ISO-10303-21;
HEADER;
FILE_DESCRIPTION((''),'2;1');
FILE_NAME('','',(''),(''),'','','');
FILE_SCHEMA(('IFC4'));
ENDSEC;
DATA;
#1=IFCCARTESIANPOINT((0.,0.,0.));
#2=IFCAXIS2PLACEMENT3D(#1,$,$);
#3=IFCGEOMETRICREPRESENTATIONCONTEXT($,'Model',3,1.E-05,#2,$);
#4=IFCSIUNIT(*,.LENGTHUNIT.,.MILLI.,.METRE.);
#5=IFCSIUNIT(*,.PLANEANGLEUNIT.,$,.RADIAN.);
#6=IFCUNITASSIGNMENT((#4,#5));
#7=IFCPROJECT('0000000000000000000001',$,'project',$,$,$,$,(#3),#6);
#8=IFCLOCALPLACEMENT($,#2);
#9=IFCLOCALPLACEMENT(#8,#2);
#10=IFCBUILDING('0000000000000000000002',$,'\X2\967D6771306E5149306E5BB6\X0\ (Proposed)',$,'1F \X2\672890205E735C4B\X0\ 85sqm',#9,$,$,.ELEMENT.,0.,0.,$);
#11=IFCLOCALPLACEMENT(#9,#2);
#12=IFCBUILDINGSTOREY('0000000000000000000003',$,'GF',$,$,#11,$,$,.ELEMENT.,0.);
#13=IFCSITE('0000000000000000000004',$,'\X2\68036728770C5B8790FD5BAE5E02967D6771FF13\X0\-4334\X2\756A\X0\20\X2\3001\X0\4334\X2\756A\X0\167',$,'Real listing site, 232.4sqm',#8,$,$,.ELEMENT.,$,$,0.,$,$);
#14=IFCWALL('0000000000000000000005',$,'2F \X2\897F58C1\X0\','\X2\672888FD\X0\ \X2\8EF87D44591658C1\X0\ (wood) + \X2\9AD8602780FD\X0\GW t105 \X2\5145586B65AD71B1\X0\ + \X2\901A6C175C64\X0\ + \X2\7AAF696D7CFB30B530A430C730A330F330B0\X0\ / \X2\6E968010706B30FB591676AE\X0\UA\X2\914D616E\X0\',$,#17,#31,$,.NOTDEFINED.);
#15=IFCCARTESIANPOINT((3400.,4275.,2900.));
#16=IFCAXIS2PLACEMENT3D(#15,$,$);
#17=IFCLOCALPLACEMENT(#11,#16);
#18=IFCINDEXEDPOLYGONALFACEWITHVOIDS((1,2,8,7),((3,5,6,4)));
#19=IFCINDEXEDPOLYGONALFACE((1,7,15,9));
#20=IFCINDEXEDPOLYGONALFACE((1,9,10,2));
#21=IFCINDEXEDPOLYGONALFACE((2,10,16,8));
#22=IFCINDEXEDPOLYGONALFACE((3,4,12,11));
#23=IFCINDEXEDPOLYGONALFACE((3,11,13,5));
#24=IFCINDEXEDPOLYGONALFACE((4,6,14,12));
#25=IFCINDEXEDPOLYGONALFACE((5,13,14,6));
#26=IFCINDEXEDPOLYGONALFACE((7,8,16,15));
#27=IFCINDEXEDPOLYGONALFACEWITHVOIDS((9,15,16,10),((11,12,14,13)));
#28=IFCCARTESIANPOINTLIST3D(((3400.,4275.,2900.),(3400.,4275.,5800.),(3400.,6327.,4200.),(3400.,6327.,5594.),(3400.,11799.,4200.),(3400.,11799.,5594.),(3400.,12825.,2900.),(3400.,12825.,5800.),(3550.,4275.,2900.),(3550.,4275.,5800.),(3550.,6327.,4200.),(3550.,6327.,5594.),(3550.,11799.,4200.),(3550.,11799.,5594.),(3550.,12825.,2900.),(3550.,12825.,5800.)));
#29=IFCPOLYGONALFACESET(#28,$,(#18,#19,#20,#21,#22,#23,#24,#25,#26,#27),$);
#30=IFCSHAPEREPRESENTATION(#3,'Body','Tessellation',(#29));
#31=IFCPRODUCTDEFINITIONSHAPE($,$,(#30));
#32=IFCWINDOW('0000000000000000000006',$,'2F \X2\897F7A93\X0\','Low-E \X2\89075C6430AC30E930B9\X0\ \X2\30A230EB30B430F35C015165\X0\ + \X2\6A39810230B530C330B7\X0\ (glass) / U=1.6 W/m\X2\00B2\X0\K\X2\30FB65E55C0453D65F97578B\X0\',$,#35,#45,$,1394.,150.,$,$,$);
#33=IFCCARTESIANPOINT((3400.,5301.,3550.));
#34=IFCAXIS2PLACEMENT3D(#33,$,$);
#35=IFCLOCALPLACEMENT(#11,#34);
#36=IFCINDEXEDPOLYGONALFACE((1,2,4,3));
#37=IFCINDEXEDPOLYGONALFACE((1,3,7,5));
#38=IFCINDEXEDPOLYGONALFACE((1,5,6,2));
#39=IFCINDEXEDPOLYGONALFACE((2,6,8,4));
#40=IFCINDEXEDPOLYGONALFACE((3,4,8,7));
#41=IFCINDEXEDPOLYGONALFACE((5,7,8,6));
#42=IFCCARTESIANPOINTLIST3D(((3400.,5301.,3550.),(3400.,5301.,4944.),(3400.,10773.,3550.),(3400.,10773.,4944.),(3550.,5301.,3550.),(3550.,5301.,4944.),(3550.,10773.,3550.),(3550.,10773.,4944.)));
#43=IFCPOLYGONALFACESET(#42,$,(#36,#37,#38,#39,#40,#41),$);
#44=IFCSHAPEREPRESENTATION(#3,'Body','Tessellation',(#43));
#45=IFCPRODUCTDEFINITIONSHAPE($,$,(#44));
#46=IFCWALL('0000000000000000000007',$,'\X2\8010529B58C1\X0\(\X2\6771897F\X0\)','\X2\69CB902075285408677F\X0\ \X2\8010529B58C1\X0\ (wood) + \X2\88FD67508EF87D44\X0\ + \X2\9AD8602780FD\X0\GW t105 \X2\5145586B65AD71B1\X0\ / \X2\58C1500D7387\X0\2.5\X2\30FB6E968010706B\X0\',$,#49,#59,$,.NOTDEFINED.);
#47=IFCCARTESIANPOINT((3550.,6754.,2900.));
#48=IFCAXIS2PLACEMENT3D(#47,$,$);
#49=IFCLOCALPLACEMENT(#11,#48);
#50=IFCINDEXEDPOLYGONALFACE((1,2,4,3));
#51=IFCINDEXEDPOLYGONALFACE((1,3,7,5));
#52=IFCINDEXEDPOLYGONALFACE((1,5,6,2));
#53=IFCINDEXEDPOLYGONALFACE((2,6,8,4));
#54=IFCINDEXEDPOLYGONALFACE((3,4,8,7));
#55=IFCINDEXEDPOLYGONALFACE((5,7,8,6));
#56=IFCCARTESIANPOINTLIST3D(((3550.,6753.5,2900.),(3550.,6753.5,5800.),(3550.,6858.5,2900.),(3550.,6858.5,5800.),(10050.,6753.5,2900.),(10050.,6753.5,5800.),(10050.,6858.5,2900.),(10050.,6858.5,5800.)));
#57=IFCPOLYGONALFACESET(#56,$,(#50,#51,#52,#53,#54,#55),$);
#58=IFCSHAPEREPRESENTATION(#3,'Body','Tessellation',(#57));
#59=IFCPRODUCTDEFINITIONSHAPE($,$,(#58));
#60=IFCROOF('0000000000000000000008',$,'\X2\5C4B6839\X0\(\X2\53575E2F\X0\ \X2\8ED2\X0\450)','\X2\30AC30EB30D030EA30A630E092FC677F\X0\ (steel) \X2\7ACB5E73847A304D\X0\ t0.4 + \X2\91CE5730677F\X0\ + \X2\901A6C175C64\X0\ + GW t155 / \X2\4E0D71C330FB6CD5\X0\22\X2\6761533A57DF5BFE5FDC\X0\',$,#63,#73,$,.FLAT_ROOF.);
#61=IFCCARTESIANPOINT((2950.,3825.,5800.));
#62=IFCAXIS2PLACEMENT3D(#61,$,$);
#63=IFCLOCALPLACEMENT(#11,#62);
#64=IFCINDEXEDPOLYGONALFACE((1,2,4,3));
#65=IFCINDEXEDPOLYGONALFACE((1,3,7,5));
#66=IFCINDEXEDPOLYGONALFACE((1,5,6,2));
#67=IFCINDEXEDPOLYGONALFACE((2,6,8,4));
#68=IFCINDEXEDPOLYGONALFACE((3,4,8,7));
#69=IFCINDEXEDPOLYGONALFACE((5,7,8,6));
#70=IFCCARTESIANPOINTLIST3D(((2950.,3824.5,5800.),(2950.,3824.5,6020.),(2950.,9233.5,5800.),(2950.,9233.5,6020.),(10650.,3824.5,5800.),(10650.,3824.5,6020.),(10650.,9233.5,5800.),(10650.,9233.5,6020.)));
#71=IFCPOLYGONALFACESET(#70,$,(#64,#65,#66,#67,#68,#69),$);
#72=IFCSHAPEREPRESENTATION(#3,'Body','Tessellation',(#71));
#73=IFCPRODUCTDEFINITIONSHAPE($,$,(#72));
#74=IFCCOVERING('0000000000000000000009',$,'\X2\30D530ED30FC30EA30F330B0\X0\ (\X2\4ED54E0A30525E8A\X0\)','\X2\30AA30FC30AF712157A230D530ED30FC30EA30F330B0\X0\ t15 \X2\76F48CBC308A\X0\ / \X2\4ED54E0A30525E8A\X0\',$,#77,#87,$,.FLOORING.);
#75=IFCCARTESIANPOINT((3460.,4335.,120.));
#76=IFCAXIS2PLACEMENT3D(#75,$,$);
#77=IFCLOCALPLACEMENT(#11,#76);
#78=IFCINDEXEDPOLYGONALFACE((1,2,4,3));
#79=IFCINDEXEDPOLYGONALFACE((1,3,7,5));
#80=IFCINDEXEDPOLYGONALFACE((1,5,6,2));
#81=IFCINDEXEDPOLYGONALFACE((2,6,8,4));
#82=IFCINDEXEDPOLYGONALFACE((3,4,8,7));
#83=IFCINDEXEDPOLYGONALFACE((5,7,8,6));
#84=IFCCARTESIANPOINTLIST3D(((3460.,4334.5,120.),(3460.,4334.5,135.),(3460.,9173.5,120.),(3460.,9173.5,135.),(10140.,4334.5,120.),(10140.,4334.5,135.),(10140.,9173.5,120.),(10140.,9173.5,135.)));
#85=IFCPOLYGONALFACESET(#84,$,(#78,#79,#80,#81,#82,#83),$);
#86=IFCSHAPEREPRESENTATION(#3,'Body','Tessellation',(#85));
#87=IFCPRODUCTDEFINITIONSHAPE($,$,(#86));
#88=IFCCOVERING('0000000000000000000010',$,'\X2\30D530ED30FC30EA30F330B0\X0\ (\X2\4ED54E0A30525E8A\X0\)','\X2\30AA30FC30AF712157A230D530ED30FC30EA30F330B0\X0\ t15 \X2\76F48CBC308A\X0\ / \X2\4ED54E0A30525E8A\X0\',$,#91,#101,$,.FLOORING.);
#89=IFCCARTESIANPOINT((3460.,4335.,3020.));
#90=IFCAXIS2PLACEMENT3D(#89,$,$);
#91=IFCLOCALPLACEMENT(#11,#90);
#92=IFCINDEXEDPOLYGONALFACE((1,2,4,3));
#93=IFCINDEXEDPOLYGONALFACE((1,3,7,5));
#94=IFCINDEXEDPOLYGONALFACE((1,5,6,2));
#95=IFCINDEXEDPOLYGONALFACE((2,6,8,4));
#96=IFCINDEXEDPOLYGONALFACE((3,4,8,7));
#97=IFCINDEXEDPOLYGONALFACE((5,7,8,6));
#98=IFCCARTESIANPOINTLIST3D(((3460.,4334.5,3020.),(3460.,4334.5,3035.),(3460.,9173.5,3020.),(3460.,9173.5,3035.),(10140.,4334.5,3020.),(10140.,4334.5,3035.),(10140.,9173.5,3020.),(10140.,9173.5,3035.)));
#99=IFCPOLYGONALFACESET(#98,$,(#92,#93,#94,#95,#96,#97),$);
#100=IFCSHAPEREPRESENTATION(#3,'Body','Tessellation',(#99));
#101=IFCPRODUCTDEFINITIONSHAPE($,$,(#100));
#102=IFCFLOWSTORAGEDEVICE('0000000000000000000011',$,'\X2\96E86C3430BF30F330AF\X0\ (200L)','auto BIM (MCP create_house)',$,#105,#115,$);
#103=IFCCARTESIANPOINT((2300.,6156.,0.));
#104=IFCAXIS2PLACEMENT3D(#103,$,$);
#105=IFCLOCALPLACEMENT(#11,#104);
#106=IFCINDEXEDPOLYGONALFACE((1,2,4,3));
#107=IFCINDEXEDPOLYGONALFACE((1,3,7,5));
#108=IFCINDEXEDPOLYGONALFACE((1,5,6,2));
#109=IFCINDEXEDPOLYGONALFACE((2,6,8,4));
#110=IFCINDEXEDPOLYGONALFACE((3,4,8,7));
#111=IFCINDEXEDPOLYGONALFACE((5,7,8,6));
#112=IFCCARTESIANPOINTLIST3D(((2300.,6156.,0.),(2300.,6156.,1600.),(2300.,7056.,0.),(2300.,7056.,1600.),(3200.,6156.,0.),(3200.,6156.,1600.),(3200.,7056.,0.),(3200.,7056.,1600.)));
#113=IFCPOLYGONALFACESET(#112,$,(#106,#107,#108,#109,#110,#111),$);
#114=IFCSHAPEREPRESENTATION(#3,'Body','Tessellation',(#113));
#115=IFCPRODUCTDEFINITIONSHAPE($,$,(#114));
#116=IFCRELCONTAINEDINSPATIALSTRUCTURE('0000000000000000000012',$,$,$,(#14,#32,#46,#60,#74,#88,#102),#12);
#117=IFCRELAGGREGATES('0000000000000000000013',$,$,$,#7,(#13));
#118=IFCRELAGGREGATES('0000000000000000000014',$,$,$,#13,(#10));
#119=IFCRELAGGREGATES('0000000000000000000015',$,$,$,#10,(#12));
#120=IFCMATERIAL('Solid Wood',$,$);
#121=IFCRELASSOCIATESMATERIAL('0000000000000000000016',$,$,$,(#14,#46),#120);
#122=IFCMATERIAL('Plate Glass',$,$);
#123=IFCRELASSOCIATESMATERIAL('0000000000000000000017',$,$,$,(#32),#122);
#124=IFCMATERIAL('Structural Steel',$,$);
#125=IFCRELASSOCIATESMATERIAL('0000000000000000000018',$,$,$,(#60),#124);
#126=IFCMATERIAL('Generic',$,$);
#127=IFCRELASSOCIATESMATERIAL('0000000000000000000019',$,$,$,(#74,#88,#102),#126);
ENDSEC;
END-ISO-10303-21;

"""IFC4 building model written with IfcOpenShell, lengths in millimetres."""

from ifc_helpers import new_model, si_unit, frame, frame_2d, origin, place, context, project, spatial, rectangle, extrude, material, element, fill, save


model = new_model("IFC4")

# Units and contexts
model_context = context("Model", 3, precision=1e-05, world=origin())
ifc_project = project(units=[si_unit("LENGTHUNIT", "METRE", prefix="MILLI"), si_unit("PLANEANGLEUNIT", "RADIAN")], contexts=[model_context])

# Site, building, storey
site_placement = place(None, origin())
site = spatial("IfcSite", under=ifc_project, at=site_placement, Name="栃木県宇都宮市陽東３-4334番20、4334番167", ObjectType="Real listing site, 232.4sqm", CompositionType="ELEMENT", RefElevation=0.0)
building_placement = place(site_placement, origin())
building = spatial("IfcBuilding", under=site, at=building_placement, Name="陽東の光の家 (Proposed)", ObjectType="1F 木造平屋 85sqm", CompositionType="ELEMENT", ElevationOfRefHeight=0.0, ElevationOfTerrain=0.0)
storey_placement = place(building_placement, origin())
storey = spatial("IfcBuildingStorey", under=building, at=storey_placement, Name="GF", CompositionType="ELEMENT", Elevation=0.0)

# Shared definitions
ifc_material_1 = material(Name="Solid Wood")
ifc_material_2 = material(Name="Generic")

# Shared definitions
ifc_material_3 = material(Name="Plate Glass")

# Wall, opening, window
wall_1_placement = place(storey_placement, frame((3400.0, 4275.0, 2900.0)))
wall_1 = element("IfcWall", 1, at=wall_1_placement, inside=storey, material=ifc_material_1, Name="2F 西壁", Description="木製 軸組外壁 (wood) + 高性能GW t105 充填断熱 + 通気層 + 窯業系サイディング / 準耐火・外皮UA配慮", PredefinedType="NOTDEFINED", context=model_context, shape_type="SweptSolid", body=[
    extrude(rectangle(XDim=150.0, YDim=8550.0, at=frame_2d((75.0, 4275.0))), frame((3400.0, 4275.0, 2900.0)), (0.0, 0.0, 1.0), 2900.0),
])
opening_1_placement = place(storey_placement, frame((3400.0, 5301.0, 3550.0)))
opening_1 = element("IfcOpeningElement", 2, at=opening_1_placement, cuts=wall_1, PredefinedType="NOTDEFINED", context=model_context, shape_type="SweptSolid", body=[
    extrude(rectangle(XDim=150.0, YDim=5472.0, at=frame_2d((75.0, 2736.0))), frame((3400.0, 5301.0, 3550.0)), (0.0, 0.0, 1.0), 1394.0),
])
window_1_placement = place(storey_placement, frame((3400.0, 5301.0, 3550.0)))
window_1 = element("IfcWindow", 3, at=window_1_placement, inside=storey, material=ifc_material_3, Name="2F 西窓", Description="Low-E 複層ガラス アルゴン封入 + 樹脂サッシ (glass) / U=1.6 W/m²K・日射取得型", OverallHeight=1394.0, OverallWidth=150.0, context=model_context, shape_type="SweptSolid", body=[
    extrude(rectangle(XDim=150.0, YDim=5472.0, at=frame_2d((75.0, 2736.0))), frame((3400.0, 5301.0, 3550.0)), (0.0, 0.0, 1.0), 1394.0),
])
fill(opening_1, window_1)

# Wall
wall_2_placement = place(storey_placement, frame((3550.0, 6754.0, 2900.0)))
element("IfcWall", 4, at=wall_2_placement, inside=storey, material=ifc_material_1, Name="耐力壁(東西)", Description="構造用合板 耐力壁 (wood) + 製材軸組 + 高性能GW t105 充填断熱 / 壁倍率2.5・準耐火", PredefinedType="NOTDEFINED", context=model_context, shape_type="SweptSolid", body=[
    extrude(rectangle(XDim=6500.0, YDim=105.0, at=frame_2d((3250.0, 52.0))), frame((3550.0, 6754.0, 2900.0)), (0.0, 0.0, 1.0), 2900.0),
])

# Roof
ifc_material_4 = material(Name="Structural Steel")
for number, where, name in (
    (5, (2950.0, 3825.0, 5800.0), "屋根(南帯 軒450)"),
):
    element("IfcRoof", number, at=place(storey_placement, frame(where)), inside=storey, material=ifc_material_4, Name=name, Description="ガルバリウム鋼板 (steel) 立平葺き t0.4 + 野地板 + 通気層 + GW t155 / 不燃・法22条区域対応", PredefinedType="FLAT_ROOF", context=model_context, shape_type="SweptSolid", body=[
        extrude(rectangle(XDim=7700.0, YDim=5409.0, at=frame_2d((3850.0, 2704.0))), frame((2950.0, 3825.0, 5800.0)), (0.0, 0.0, 1.0), 220.0),
    ])

# Coverings
covering_1_placement = place(storey_placement, frame((3460.0, 4335.0, 120.0)))
element("IfcCovering", 6, at=covering_1_placement, inside=storey, material=ifc_material_2, Name="フローリング (仕上げ床)", Description="オーク無垢フローリング t15 直貼り / 仕上げ床", PredefinedType="FLOORING", context=model_context, shape_type="SweptSolid", body=[
    extrude(rectangle(XDim=6680.0, YDim=4839.0, at=frame_2d((3340.0, 2419.0))), frame((3460.0, 4335.0, 120.0)), (0.0, 0.0, 1.0), 15.0),
])
covering_2_placement = place(storey_placement, frame((3460.0, 4335.0, 3020.0)))
element("IfcCovering", 7, at=covering_2_placement, inside=storey, material=ifc_material_2, Name="フローリング (仕上げ床)", Description="オーク無垢フローリング t15 直貼り / 仕上げ床", PredefinedType="FLOORING", context=model_context, shape_type="SweptSolid", body=[
    extrude(rectangle(XDim=6680.0, YDim=4839.0, at=frame_2d((3340.0, 2419.0))), frame((3460.0, 4335.0, 3020.0)), (0.0, 0.0, 1.0), 15.0),
])

# Flow storage device
flow_storage_device_placement = place(storey_placement, frame((2300.0, 6156.0, 0.0)))
element("IfcFlowStorageDevice", 8, at=flow_storage_device_placement, inside=storey, material=ifc_material_2, Name="雨水タンク (200L)", Description="auto BIM (MCP create_house)", context=model_context, shape_type="SweptSolid", body=[
    extrude(rectangle(XDim=900.0, YDim=900.0, at=frame_2d((450.0, 450.0))), frame((2300.0, 6156.0, 0.0)), (0.0, 0.0, 1.0), 1600.0),
])

save(model, "model.ifc")
